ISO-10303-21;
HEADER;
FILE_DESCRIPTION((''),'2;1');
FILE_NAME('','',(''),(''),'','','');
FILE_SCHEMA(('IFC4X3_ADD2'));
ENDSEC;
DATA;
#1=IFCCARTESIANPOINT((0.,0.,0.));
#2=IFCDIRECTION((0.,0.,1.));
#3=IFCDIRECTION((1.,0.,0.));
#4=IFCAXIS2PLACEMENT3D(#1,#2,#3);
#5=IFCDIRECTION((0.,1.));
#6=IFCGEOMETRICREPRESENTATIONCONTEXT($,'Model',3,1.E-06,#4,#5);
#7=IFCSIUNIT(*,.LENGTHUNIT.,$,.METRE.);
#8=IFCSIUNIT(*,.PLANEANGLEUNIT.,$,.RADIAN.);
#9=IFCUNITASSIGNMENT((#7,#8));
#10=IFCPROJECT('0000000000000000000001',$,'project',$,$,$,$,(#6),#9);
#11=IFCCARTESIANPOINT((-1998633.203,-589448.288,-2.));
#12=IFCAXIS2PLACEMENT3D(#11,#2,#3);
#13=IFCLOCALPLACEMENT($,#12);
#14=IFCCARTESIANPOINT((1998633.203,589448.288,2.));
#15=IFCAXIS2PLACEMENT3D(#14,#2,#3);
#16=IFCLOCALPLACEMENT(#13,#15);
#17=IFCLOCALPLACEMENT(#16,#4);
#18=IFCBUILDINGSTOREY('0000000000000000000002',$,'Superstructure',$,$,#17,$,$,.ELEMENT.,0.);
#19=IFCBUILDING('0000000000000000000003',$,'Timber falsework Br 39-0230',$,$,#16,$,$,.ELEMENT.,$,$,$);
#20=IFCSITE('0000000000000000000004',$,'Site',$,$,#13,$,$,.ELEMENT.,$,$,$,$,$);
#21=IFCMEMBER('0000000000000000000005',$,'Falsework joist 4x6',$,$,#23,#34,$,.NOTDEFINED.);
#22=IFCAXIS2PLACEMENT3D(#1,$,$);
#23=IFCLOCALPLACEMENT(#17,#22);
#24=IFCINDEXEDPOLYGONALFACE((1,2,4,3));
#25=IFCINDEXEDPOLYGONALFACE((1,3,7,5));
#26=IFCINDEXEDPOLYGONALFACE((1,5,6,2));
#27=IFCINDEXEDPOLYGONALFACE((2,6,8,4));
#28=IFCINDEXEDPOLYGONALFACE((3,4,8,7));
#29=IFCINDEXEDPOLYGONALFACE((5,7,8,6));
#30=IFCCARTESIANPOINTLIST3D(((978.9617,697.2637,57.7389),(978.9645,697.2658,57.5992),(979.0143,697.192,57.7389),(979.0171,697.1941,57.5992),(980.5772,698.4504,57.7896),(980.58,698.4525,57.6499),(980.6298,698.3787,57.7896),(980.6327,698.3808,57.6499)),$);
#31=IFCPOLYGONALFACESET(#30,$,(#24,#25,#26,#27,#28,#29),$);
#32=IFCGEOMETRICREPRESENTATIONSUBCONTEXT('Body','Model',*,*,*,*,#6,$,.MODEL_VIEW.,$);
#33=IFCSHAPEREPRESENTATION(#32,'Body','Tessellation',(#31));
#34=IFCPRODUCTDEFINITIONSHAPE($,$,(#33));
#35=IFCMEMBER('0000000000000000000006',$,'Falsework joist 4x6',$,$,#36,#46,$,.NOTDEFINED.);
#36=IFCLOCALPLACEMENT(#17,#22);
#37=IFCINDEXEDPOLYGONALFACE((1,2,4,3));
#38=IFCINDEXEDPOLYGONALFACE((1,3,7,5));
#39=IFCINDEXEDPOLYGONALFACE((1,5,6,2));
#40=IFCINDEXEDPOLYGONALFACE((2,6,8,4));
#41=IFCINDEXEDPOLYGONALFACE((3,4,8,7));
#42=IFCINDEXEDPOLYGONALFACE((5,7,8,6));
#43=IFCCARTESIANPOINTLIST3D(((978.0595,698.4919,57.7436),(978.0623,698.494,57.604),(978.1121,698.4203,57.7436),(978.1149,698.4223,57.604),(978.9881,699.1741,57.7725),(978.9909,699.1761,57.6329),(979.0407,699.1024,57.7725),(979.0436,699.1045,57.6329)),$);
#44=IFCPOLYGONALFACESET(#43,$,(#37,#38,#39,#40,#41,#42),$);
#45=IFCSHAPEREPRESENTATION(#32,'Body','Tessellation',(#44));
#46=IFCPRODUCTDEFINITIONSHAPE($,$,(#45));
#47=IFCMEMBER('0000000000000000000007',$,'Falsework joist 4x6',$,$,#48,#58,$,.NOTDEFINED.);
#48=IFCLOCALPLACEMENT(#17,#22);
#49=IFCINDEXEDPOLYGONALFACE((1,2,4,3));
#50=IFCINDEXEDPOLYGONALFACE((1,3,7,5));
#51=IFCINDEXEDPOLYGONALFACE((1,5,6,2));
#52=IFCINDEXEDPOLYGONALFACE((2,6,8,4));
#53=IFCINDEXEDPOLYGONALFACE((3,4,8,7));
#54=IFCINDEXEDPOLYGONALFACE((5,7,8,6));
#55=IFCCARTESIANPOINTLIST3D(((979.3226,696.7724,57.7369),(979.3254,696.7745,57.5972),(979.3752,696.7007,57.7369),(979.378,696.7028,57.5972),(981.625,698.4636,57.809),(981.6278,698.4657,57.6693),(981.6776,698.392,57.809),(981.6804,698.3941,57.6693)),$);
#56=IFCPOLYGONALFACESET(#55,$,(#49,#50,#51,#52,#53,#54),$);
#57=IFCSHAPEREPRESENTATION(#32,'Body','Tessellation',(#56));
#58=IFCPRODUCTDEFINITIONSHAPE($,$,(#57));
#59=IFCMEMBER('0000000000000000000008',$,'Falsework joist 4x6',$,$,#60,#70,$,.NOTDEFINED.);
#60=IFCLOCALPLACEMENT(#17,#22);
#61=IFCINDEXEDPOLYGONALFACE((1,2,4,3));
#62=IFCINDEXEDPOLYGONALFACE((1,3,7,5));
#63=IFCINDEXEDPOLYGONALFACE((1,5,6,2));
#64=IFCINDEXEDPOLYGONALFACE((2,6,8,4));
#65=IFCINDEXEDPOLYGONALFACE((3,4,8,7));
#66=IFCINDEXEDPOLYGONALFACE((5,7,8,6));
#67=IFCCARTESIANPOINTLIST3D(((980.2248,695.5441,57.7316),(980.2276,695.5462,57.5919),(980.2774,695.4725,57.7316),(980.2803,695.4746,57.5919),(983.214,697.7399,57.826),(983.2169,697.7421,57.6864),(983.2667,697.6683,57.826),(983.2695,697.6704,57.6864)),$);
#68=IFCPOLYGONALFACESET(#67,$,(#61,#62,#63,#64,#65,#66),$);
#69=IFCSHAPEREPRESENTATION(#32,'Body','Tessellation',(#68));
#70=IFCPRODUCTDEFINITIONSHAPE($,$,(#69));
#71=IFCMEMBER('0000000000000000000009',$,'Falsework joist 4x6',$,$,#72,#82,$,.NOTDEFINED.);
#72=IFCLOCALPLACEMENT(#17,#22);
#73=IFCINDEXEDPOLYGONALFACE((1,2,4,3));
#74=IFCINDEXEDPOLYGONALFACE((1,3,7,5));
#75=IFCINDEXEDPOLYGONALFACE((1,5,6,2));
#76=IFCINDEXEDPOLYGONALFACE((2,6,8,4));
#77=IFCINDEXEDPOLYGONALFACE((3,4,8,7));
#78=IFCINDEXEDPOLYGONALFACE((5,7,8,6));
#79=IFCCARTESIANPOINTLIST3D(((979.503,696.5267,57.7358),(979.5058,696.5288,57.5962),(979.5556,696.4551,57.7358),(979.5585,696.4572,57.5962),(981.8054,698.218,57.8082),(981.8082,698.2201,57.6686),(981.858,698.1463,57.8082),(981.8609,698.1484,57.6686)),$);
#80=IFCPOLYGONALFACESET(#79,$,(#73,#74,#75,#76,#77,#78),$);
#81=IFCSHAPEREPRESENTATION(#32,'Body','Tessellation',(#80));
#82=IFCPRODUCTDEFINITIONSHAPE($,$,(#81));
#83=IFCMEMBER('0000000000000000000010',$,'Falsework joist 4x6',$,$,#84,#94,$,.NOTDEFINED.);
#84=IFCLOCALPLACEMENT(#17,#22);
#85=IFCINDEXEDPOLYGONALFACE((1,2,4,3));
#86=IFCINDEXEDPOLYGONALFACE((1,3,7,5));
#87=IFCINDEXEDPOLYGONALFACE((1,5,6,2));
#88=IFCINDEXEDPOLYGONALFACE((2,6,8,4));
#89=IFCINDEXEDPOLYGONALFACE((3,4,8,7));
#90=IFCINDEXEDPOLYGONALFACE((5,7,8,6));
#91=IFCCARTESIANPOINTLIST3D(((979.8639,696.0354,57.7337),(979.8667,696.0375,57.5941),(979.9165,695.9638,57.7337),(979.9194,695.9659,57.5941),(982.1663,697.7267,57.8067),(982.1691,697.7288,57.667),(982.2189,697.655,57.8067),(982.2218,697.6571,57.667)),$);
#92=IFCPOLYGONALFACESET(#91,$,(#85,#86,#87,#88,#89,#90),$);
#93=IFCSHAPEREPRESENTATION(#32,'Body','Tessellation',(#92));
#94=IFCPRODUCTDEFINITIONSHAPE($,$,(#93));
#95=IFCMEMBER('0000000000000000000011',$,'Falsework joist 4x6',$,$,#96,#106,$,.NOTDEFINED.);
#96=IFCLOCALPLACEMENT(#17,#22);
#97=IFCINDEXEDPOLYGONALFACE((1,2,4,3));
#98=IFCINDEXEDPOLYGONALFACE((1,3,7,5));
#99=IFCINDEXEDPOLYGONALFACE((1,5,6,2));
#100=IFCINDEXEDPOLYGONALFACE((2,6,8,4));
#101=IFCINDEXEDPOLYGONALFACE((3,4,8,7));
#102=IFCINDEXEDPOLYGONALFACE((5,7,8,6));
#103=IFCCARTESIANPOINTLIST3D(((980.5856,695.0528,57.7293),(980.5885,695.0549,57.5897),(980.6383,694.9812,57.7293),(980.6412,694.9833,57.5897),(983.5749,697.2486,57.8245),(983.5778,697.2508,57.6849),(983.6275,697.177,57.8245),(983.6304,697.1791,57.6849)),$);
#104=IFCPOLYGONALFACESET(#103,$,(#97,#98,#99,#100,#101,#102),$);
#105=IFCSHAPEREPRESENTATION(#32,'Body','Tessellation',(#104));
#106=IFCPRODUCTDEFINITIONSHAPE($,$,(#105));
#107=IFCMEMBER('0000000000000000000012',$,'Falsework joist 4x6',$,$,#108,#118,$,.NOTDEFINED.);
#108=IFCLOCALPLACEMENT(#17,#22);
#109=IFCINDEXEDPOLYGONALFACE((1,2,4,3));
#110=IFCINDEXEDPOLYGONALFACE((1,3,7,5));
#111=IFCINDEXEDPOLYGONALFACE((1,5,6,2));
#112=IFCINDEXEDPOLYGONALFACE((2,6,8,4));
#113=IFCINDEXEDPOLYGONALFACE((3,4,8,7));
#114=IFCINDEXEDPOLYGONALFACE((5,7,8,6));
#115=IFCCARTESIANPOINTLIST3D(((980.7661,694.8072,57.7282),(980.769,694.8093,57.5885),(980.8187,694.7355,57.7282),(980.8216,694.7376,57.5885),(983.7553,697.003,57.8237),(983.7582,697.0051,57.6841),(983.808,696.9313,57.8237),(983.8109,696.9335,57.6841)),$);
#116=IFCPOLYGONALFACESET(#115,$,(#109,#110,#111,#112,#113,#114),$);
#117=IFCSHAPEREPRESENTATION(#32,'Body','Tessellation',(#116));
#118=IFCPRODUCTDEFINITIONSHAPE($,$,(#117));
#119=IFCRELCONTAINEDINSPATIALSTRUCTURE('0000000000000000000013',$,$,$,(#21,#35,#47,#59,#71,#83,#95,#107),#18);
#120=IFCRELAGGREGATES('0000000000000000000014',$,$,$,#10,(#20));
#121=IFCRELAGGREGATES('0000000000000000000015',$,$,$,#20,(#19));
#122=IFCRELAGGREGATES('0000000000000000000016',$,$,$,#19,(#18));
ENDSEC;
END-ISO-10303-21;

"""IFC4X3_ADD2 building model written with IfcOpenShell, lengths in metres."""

from ifc_helpers import new_model, si_unit, direction, frame, frame_2d, origin, origin_with_axes, place, context, subcontext, project, spatial, rectangle, extrude, element, save


model = new_model("IFC4X3_ADD2")

# Units and contexts
model_context = context("Model", 3, precision=1e-06, world=origin_with_axes(), true_north=direction((0.0, 1.0)))
body_context = subcontext(model_context, "Body", "Model", "MODEL_VIEW")
ifc_project = project(units=[si_unit("LENGTHUNIT", "METRE"), si_unit("PLANEANGLEUNIT", "RADIAN")], contexts=[model_context])

# Site, building, storey
site_placement = place(None, frame((-1998633.203, -589448.288, -2.0), z_axis=(0.0, 0.0, 1.0), x_axis=(1.0, 0.0, 0.0)))
site = spatial("IfcSite", under=ifc_project, at=site_placement, Name="Site", CompositionType="ELEMENT")
building_placement = place(site_placement, frame((1998633.203, 589448.288, 2.0), z_axis=(0.0, 0.0, 1.0), x_axis=(1.0, 0.0, 0.0)))
building = spatial("IfcBuilding", under=site, at=building_placement, Name="Timber falsework Br 39-0230", CompositionType="ELEMENT")
storey_placement = place(building_placement, origin_with_axes())
storey = spatial("IfcBuildingStorey", under=building, at=storey_placement, Name="Superstructure", CompositionType="ELEMENT", Elevation=0.0)

# Members
member_1_placement = place(storey_placement, frame((978.9908, 697.2299, 57.5992), z_axis=(0.805671, 0.591824, 0.025279), x_axis=(-0.592013, 0.805928, 0.0)))
element("IfcMember", 1, at=member_1_placement, inside=storey, Name="Falsework joist 4x6", PredefinedType="NOTDEFINED", context=body_context, shape_type="SweptSolid", body=[
    extrude(rectangle(XDim=0.0889, YDim=0.1397, at=frame_2d((0.0, 0.0698))), origin(), (0.0, 0.0, 1.0), 2.0052),
])
member_2_placement = place(storey_placement, frame((978.0886, 698.4582, 57.604), z_axis=(0.805676, 0.591827, 0.025044), x_axis=(-0.592013, 0.805928, 0.0)))
element("IfcMember", 2, at=member_2_placement, inside=storey, Name="Falsework joist 4x6", PredefinedType="NOTDEFINED", context=body_context, shape_type="SweptSolid", body=[
    extrude(rectangle(XDim=0.0889, YDim=0.1397, at=frame_2d((0.0, 0.0698))), origin(), (0.0, 0.0, 1.0), 1.1526),
])
member_3_placement = place(storey_placement, frame((979.3517, 696.7386, 57.5972), z_axis=(0.805672, 0.591825, 0.02523), x_axis=(-0.592013, 0.805928, 0.0)))
element("IfcMember", 3, at=member_3_placement, inside=storey, Name="Falsework joist 4x6", PredefinedType="NOTDEFINED", context=body_context, shape_type="SweptSolid", body=[
    extrude(rectangle(XDim=0.0889, YDim=0.1397, at=frame_2d((0.0, 0.0698))), origin(), (0.0, 0.0, 1.0), 2.8577),
])
member_4_placement = place(storey_placement, frame((980.2539, 695.5104, 57.5919), z_axis=(0.805667, 0.591821, 0.025465), x_axis=(-0.592013, 0.805928, 0.0)))
element("IfcMember", 4, at=member_4_placement, inside=storey, Name="Falsework joist 4x6", PredefinedType="NOTDEFINED", context=body_context, shape_type="SweptSolid", body=[
    extrude(rectangle(XDim=0.0889, YDim=0.1397, at=frame_2d((0.0, 0.0698))), origin(), (0.0, 0.0, 1.0), 3.7103),
])
member_5_placement = place(storey_placement, frame((979.5322, 696.493, 57.5962), z_axis=(0.80567, 0.591823, 0.025325), x_axis=(-0.592013, 0.805928, 0.0)))
element("IfcMember", 5, at=member_5_placement, inside=storey, Name="Falsework joist 4x6", PredefinedType="NOTDEFINED", context=body_context, shape_type="SweptSolid", body=[
    extrude(rectangle(XDim=0.0889, YDim=0.1397, at=frame_2d((0.0, 0.0698))), origin(), (0.0, 0.0, 1.0), 2.8577),
])
member_6_placement = place(storey_placement, frame((979.8931, 696.0017, 57.5941), z_axis=(0.805666, 0.59182, 0.025514), x_axis=(-0.592013, 0.805928, 0.0)))
element("IfcMember", 6, at=member_6_placement, inside=storey, Name="Falsework joist 4x6", PredefinedType="NOTDEFINED", context=body_context, shape_type="SweptSolid", body=[
    extrude(rectangle(XDim=0.0889, YDim=0.1397, at=frame_2d((0.0, 0.0698))), origin(), (0.0, 0.0, 1.0), 2.8577),
])
member_7_placement = place(storey_placement, frame((980.6148, 695.0191, 57.5897), z_axis=(0.805663, 0.591818, 0.025655), x_axis=(-0.592013, 0.805928, 0.0)))
element("IfcMember", 7, at=member_7_placement, inside=storey, Name="Falsework joist 4x6", PredefinedType="NOTDEFINED", context=body_context, shape_type="SweptSolid", body=[
    extrude(rectangle(XDim=0.0889, YDim=0.1397, at=frame_2d((0.0, 0.0698))), origin(), (0.0, 0.0, 1.0), 3.7103),
])
member_8_placement = place(storey_placement, frame((980.7953, 694.7735, 57.5885), z_axis=(0.805661, 0.591817, 0.025749), x_axis=(-0.592013, 0.805928, 0.0)))
element("IfcMember", 8, at=member_8_placement, inside=storey, Name="Falsework joist 4x6", PredefinedType="NOTDEFINED", context=body_context, shape_type="SweptSolid", body=[
    extrude(rectangle(XDim=0.0889, YDim=0.1397, at=frame_2d((0.0, 0.0698))), origin(), (0.0, 0.0, 1.0), 3.7103),
])

save(model, "model.ifc")
